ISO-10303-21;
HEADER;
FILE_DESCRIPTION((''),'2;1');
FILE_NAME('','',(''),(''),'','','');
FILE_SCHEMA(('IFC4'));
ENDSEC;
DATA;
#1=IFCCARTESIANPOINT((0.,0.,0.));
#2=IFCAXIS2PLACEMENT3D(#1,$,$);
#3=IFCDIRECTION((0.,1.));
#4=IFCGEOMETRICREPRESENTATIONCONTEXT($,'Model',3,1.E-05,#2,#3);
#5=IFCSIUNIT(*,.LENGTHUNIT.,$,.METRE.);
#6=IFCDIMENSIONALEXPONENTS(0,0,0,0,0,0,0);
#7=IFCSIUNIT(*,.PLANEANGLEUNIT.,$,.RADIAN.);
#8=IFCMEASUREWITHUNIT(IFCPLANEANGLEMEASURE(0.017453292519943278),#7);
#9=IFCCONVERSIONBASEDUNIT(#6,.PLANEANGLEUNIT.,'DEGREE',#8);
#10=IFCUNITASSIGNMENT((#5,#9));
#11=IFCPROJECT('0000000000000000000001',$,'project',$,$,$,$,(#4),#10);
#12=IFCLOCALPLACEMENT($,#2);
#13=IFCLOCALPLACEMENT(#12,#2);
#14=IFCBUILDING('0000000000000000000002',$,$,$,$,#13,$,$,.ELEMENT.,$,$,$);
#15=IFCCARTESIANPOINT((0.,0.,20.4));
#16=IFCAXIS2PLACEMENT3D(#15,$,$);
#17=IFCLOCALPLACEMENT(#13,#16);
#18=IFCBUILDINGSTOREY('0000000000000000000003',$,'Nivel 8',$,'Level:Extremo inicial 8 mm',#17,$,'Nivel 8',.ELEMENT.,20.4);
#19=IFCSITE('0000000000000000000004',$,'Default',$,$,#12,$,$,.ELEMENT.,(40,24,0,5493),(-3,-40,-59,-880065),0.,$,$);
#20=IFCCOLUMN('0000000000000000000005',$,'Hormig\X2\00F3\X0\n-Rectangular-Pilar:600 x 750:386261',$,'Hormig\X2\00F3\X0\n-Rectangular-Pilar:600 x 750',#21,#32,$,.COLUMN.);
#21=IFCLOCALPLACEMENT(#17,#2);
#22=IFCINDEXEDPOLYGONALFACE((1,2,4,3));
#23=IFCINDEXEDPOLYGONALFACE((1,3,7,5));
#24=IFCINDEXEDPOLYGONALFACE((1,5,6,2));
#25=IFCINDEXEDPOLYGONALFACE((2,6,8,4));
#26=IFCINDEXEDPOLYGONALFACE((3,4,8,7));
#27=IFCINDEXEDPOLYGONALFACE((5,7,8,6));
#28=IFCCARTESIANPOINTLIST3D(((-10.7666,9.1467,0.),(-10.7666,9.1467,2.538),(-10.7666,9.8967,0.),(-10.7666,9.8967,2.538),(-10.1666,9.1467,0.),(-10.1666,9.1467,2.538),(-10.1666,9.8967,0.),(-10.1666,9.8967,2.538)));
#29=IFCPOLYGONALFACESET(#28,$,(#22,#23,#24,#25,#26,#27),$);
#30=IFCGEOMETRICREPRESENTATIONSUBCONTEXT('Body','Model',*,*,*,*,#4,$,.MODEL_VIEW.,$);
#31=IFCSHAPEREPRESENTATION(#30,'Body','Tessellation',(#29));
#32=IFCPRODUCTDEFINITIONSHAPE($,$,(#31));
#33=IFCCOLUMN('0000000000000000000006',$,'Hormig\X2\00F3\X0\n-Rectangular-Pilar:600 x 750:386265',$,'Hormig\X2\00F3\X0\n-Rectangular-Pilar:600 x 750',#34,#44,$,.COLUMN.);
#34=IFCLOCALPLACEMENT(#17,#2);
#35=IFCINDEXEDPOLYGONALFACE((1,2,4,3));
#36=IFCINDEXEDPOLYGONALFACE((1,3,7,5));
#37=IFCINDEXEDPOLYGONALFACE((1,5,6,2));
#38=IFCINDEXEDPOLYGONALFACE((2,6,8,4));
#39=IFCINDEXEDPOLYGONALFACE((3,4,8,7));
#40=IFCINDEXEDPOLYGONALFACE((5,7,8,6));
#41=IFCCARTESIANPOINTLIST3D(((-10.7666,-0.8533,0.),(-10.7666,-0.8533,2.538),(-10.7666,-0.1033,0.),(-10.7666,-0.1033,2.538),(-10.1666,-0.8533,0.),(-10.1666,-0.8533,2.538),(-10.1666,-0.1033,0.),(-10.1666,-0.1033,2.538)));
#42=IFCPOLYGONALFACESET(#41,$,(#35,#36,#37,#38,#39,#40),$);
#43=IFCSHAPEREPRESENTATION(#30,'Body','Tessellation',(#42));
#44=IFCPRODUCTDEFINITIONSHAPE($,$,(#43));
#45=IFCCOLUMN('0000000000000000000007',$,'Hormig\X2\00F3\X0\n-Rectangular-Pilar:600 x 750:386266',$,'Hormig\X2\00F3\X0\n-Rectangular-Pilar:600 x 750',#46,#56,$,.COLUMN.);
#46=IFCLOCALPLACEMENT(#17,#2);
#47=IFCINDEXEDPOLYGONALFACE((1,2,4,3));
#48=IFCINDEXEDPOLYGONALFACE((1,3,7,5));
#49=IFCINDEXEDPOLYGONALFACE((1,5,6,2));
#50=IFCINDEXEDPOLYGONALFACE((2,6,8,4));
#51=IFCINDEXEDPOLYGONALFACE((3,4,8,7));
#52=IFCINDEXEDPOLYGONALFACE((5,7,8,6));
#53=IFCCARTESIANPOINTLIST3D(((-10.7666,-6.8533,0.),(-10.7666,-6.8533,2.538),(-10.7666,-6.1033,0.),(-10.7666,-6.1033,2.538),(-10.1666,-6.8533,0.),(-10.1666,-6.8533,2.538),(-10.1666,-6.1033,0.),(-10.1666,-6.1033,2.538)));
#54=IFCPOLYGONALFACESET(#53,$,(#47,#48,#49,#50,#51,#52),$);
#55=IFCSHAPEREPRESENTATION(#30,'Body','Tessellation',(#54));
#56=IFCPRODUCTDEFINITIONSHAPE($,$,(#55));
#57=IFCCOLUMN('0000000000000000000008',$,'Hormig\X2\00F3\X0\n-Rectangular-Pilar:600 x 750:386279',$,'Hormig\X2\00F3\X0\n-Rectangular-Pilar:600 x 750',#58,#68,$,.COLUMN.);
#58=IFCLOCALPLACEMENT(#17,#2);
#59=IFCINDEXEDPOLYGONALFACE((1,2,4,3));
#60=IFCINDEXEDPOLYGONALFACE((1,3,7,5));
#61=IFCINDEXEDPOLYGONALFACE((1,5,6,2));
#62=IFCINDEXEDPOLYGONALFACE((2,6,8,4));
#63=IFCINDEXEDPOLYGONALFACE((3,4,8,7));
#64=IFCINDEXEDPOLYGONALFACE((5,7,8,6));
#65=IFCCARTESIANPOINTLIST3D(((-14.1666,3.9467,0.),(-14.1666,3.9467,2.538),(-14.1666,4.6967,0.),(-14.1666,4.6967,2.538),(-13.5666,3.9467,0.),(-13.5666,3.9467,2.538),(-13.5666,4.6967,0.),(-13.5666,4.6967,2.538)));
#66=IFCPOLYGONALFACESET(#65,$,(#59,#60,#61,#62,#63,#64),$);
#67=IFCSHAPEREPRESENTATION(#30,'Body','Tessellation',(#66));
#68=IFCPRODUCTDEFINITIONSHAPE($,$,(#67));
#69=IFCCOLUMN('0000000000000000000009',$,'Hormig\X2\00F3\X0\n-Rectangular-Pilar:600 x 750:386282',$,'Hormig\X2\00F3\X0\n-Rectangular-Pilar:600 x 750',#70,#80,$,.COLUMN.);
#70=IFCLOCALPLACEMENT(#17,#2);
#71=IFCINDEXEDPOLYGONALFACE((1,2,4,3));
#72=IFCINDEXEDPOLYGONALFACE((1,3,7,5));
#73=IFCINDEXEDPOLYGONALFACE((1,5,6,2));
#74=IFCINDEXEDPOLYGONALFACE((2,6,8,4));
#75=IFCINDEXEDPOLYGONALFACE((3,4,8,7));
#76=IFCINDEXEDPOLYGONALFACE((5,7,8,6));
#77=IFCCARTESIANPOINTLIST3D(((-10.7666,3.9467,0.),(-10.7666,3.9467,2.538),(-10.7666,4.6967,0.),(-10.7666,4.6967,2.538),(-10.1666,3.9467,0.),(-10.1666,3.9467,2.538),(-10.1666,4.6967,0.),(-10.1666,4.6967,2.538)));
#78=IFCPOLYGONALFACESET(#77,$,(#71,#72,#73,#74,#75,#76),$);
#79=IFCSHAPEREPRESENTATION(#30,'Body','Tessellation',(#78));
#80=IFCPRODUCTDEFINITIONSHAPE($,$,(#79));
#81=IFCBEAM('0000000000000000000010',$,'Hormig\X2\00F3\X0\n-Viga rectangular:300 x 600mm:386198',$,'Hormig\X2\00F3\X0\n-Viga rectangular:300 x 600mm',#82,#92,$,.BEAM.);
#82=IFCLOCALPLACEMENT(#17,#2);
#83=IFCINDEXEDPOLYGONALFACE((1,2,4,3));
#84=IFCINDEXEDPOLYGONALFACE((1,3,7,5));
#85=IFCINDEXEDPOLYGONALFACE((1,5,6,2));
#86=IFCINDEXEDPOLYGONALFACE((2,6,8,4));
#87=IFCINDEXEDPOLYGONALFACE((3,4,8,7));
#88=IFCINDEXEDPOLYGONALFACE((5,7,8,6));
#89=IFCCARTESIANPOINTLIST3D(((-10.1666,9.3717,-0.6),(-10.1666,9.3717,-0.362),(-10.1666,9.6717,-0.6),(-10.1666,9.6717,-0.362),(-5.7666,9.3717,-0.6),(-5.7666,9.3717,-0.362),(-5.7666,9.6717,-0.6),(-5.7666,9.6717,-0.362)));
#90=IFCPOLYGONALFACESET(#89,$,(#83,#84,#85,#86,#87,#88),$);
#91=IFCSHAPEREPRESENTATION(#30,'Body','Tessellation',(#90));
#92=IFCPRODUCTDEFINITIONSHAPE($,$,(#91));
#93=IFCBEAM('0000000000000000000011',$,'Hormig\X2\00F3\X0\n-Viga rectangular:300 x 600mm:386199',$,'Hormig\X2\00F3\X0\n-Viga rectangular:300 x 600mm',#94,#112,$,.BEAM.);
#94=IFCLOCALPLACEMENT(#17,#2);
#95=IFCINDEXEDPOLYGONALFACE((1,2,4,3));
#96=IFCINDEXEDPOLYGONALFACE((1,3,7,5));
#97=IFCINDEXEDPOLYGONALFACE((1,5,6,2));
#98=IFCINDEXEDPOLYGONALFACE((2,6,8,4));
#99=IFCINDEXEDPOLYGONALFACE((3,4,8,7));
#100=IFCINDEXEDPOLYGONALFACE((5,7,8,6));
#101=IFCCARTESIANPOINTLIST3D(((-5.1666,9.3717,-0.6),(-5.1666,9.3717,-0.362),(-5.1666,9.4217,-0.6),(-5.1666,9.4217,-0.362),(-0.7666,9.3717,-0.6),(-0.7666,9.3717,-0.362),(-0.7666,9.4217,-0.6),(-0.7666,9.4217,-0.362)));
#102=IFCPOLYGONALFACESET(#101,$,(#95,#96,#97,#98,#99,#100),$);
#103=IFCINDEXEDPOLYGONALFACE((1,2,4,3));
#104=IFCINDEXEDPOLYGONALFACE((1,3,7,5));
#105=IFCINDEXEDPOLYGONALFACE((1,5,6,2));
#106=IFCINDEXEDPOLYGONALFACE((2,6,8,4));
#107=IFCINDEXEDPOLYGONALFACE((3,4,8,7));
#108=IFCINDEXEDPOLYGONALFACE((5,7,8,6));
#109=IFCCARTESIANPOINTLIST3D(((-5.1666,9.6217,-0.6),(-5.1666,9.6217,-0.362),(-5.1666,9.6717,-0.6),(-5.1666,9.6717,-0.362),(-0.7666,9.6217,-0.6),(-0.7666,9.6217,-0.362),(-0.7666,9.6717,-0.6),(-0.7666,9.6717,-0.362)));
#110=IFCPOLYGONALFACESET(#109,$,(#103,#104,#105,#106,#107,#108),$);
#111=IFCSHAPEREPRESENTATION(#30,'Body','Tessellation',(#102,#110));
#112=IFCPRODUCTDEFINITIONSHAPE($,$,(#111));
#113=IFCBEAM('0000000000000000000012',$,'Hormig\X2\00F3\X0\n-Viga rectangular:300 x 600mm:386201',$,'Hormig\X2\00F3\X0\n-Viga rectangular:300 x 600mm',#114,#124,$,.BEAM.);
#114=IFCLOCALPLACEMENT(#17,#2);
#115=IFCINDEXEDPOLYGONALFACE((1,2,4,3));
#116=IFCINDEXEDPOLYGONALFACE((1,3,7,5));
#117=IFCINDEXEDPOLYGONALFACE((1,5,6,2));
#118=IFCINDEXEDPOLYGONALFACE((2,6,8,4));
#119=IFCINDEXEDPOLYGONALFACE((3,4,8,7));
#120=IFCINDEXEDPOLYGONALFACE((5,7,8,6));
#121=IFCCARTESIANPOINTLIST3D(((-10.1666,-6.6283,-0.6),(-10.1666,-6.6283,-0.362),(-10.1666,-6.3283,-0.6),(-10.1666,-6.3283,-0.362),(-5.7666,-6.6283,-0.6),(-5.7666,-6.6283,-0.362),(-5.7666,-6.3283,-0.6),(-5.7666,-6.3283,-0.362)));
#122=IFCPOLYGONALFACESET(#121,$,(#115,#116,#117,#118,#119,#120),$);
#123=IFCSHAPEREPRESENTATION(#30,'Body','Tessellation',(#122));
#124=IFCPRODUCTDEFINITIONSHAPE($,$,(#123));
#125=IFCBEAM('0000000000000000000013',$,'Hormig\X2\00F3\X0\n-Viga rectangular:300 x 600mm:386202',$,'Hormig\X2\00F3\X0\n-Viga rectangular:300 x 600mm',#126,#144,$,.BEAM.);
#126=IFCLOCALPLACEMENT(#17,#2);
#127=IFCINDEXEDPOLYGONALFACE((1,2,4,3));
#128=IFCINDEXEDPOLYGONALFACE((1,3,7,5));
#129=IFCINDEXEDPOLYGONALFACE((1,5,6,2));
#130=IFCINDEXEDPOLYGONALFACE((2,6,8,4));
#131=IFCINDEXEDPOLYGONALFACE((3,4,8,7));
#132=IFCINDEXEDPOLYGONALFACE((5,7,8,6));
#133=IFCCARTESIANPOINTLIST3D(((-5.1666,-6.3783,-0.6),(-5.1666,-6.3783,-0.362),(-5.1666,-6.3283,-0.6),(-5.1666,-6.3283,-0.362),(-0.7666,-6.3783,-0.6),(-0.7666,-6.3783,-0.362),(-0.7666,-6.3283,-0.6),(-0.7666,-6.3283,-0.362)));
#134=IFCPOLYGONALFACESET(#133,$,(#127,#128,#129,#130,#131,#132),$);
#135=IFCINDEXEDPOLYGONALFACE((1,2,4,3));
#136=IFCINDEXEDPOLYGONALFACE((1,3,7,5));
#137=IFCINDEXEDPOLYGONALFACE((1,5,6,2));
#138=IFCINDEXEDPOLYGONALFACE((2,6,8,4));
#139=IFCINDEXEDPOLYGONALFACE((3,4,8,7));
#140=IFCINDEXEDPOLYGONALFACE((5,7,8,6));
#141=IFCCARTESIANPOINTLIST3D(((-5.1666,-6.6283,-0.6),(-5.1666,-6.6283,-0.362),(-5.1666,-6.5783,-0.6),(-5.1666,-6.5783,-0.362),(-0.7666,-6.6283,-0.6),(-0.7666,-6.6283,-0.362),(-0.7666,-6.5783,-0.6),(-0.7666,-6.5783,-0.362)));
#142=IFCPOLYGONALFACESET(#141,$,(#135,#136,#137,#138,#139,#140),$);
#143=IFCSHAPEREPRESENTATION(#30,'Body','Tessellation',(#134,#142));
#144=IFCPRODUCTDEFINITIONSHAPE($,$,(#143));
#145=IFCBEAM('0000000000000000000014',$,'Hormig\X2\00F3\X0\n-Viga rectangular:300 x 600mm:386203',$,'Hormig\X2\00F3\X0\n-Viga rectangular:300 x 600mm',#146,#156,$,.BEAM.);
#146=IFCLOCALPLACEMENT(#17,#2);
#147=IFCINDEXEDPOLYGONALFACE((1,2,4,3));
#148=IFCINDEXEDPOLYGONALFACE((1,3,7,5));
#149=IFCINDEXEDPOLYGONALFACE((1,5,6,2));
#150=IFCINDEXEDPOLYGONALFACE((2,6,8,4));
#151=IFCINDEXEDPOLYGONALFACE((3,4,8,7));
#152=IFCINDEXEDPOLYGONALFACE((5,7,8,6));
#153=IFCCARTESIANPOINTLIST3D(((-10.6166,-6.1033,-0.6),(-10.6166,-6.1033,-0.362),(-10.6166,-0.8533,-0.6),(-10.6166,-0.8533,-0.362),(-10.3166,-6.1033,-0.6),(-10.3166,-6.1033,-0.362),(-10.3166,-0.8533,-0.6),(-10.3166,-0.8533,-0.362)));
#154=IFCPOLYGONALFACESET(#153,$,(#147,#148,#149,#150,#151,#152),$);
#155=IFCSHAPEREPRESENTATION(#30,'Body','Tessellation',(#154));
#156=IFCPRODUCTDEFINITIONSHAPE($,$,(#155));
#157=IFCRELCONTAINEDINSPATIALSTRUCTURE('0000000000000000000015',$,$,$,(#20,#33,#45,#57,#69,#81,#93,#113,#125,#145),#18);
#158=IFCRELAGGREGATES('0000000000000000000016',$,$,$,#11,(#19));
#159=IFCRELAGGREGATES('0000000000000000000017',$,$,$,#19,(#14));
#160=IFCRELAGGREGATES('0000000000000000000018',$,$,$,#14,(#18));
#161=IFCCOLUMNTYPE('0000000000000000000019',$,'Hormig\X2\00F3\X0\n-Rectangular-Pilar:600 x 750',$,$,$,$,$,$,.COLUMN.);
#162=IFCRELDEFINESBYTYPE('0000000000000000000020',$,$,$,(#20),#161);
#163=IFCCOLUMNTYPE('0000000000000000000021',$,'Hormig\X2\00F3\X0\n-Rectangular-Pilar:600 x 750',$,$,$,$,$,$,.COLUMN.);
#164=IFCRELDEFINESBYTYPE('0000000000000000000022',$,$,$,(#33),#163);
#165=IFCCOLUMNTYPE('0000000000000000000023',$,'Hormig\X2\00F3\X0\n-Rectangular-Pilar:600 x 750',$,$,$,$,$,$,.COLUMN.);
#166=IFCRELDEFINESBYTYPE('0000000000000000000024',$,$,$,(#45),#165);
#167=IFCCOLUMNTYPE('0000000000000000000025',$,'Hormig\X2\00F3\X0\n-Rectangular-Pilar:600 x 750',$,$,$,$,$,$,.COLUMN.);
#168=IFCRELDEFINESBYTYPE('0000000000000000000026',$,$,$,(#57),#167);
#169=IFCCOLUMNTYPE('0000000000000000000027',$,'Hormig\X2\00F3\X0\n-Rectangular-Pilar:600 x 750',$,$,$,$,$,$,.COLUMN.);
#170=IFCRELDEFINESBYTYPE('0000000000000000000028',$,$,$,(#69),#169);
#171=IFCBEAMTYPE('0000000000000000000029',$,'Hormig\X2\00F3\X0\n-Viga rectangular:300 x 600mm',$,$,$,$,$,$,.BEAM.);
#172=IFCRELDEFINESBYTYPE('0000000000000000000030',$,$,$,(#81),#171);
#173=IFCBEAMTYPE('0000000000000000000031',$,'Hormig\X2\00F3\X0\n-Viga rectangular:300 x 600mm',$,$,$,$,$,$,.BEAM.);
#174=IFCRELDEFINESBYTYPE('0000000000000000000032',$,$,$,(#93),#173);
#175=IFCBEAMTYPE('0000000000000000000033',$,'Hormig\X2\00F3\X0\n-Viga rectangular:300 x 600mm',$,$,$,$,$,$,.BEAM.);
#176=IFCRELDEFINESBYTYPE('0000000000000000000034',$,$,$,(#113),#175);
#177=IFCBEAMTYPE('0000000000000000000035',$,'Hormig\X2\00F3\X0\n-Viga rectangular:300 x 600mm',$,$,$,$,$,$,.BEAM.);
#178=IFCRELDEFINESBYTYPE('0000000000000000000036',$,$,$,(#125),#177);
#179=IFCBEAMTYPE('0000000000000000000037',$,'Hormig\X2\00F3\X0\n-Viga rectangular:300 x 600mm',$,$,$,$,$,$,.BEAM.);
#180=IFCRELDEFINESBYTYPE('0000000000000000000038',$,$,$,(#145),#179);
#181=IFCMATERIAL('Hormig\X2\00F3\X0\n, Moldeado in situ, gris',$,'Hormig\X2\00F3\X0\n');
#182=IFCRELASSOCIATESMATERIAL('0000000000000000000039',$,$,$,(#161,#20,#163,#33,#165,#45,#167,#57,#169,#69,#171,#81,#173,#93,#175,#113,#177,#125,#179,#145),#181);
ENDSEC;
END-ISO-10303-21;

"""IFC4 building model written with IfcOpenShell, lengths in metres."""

from ifc_helpers import new_model, entity, si_unit, converted_unit, direction, frame, origin, place, context, subcontext, project, spatial, indexed_curve, outline, extrude, source, transform, mapped, material, type_object, type_shapes, element, save


model = new_model("IFC4")

# Units and contexts
model_context = context("Model", 3, precision=1e-05, world=origin(), true_north=direction((0.0, 1.0)))
body_context = subcontext(model_context, "Body", "Model", "MODEL_VIEW")
ifc_project = project(units=[si_unit("LENGTHUNIT", "METRE"), converted_unit("PLANEANGLEUNIT", "DEGREE", entity("IfcPlaneAngleMeasure", 0.017453292519943278), si_unit("PLANEANGLEUNIT", "RADIAN"), dimensions=[0, 0, 0, 0, 0, 0, 0])], contexts=[model_context])

# Site, building, storey
site_placement = place(None, origin())
site = spatial("IfcSite", under=ifc_project, at=site_placement, Name="Default", CompositionType="ELEMENT", RefLatitude=(40, 24, 0, 5493), RefLongitude=(-3, -40, -59, -880065), RefElevation=0.0)
building_placement = place(site_placement, origin())
building = spatial("IfcBuilding", under=site, at=building_placement, CompositionType="ELEMENT")
storey_placement = place(building_placement, frame((0.0, 0.0, 20.4)))
storey = spatial("IfcBuildingStorey", under=building, at=storey_placement, Name="Nivel 8", ObjectType="Level:Extremo inicial 8 mm", LongName="Nivel 8", CompositionType="ELEMENT", Elevation=20.4)

# Columns
ifc_material_1 = material(Name="Hormigón, Moldeado in situ, gris", Category="Hormigón")
column_type_1 = type_object("IfcColumnType", Name="Hormigón-Rectangular-Pilar:600 x 750", PredefinedType="COLUMN", material=ifc_material_1)
shared_shape_1 = source(origin(), body_context, "Body", "SweptSolid", [
    extrude(outline(indexed_curve([(-0.3, -0.375), (0.3, -0.375), (0.3, 0.375), (-0.3, 0.375), (-0.3, -0.375)], self_intersect=False)), frame((-10.4666, 9.5217, 20.4), z_axis=(0.0, 0.0, 1.0), x_axis=(-1.0, 0.0, 0.0)), (0.0, 0.0, 1.0), 2.538),
])
type_shapes(column_type_1, [shared_shape_1])
column_1_placement = place(storey_placement, frame((0.0, 0.0, -20.4)))
element("IfcColumn", 1, at=column_1_placement, inside=storey, type_object=column_type_1, material=ifc_material_1, Name="Hormigón-Rectangular-Pilar:600 x 750:386261", ObjectType="Hormigón-Rectangular-Pilar:600 x 750", PredefinedType="COLUMN", context=body_context, shape_type="MappedRepresentation", body=[
    mapped(shared_shape_1, transform((0.0, 0.0, 0.0), scale=1.0)),
])
column_type_2 = type_object("IfcColumnType", Name="Hormigón-Rectangular-Pilar:600 x 750", PredefinedType="COLUMN", material=ifc_material_1)
shared_shape_2 = source(origin(), body_context, "Body", "SweptSolid", [
    extrude(outline(indexed_curve([(-0.3, -0.375), (0.3, -0.375), (0.3, 0.375), (-0.3, 0.375), (-0.3, -0.375)], self_intersect=False)), frame((-10.4666, -0.4783, 20.4), z_axis=(0.0, 0.0, 1.0), x_axis=(-1.0, 0.0, 0.0)), (0.0, 0.0, 1.0), 2.538),
])
type_shapes(column_type_2, [shared_shape_2])
column_2_placement = place(storey_placement, frame((0.0, 0.0, -20.4)))
element("IfcColumn", 2, at=column_2_placement, inside=storey, type_object=column_type_2, material=ifc_material_1, Name="Hormigón-Rectangular-Pilar:600 x 750:386265", ObjectType="Hormigón-Rectangular-Pilar:600 x 750", PredefinedType="COLUMN", context=body_context, shape_type="MappedRepresentation", body=[
    mapped(shared_shape_2, transform((0.0, 0.0, 0.0), scale=1.0)),
])
column_type_3 = type_object("IfcColumnType", Name="Hormigón-Rectangular-Pilar:600 x 750", PredefinedType="COLUMN", material=ifc_material_1)
shared_shape_3 = source(origin(), body_context, "Body", "SweptSolid", [
    extrude(outline(indexed_curve([(-0.3, -0.375), (0.3, -0.375), (0.3, 0.375), (-0.3, 0.375), (-0.3, -0.375)], self_intersect=False)), frame((-10.4666, -6.4783, 20.4), z_axis=(0.0, 0.0, 1.0), x_axis=(-1.0, 0.0, 0.0)), (0.0, 0.0, 1.0), 2.538),
])
type_shapes(column_type_3, [shared_shape_3])
column_3_placement = place(storey_placement, frame((0.0, 0.0, -20.4)))
element("IfcColumn", 3, at=column_3_placement, inside=storey, type_object=column_type_3, material=ifc_material_1, Name="Hormigón-Rectangular-Pilar:600 x 750:386266", ObjectType="Hormigón-Rectangular-Pilar:600 x 750", PredefinedType="COLUMN", context=body_context, shape_type="MappedRepresentation", body=[
    mapped(shared_shape_3, transform((0.0, 0.0, 0.0), scale=1.0)),
])
column_type_4 = type_object("IfcColumnType", Name="Hormigón-Rectangular-Pilar:600 x 750", PredefinedType="COLUMN", material=ifc_material_1)
shared_shape_4 = source(origin(), body_context, "Body", "SweptSolid", [
    extrude(outline(indexed_curve([(-0.3, -0.375), (0.3, -0.375), (0.3, 0.375), (-0.3, 0.375), (-0.3, -0.375)], self_intersect=False)), frame((-13.8666, 4.3217, 20.4), z_axis=(0.0, 0.0, 1.0), x_axis=(-1.0, 0.0, 0.0)), (0.0, 0.0, 1.0), 2.538),
])
type_shapes(column_type_4, [shared_shape_4])
column_4_placement = place(storey_placement, frame((0.0, 0.0, -20.4)))
element("IfcColumn", 4, at=column_4_placement, inside=storey, type_object=column_type_4, material=ifc_material_1, Name="Hormigón-Rectangular-Pilar:600 x 750:386279", ObjectType="Hormigón-Rectangular-Pilar:600 x 750", PredefinedType="COLUMN", context=body_context, shape_type="MappedRepresentation", body=[
    mapped(shared_shape_4, transform((0.0, 0.0, 0.0), scale=1.0)),
])
column_type_5 = type_object("IfcColumnType", Name="Hormigón-Rectangular-Pilar:600 x 750", PredefinedType="COLUMN", material=ifc_material_1)
shared_shape_5 = source(origin(), body_context, "Body", "SweptSolid", [
    extrude(outline(indexed_curve([(-0.3, -0.375), (0.3, -0.375), (0.3, 0.375), (-0.3, 0.375), (-0.3, -0.375)], self_intersect=False)), frame((-10.4666, 4.3217, 20.4), z_axis=(0.0, 0.0, 1.0), x_axis=(-1.0, 0.0, 0.0)), (0.0, 0.0, 1.0), 2.538),
])
type_shapes(column_type_5, [shared_shape_5])
column_5_placement = place(storey_placement, frame((0.0, 0.0, -20.4)))
element("IfcColumn", 5, at=column_5_placement, inside=storey, type_object=column_type_5, material=ifc_material_1, Name="Hormigón-Rectangular-Pilar:600 x 750:386282", ObjectType="Hormigón-Rectangular-Pilar:600 x 750", PredefinedType="COLUMN", context=body_context, shape_type="MappedRepresentation", body=[
    mapped(shared_shape_5, transform((0.0, 0.0, 0.0), scale=1.0)),
])

# Beams
beam_type_1 = type_object("IfcBeamType", Name="Hormigón-Viga rectangular:300 x 600mm", PredefinedType="BEAM", material=ifc_material_1)
shared_shape_6 = source(origin(), body_context, "Body", "SweptSolid", [
    extrude(outline(indexed_curve([(-0.119, -0.15), (0.119, -0.15), (0.119, 0.15), (-0.119, 0.15), (-0.119, -0.15)], self_intersect=False)), frame((-5.7666, 9.5217, 19.919), z_axis=(-1.0, 0.0, 0.0), x_axis=(0.0, 0.0, -1.0)), (0.0, 0.0, 1.0), 4.4),
])
type_shapes(beam_type_1, [shared_shape_6])
beam_1_placement = place(storey_placement, frame((0.0, 0.0, -20.4)))
element("IfcBeam", 6, at=beam_1_placement, inside=storey, type_object=beam_type_1, material=ifc_material_1, Name="Hormigón-Viga rectangular:300 x 600mm:386198", ObjectType="Hormigón-Viga rectangular:300 x 600mm", PredefinedType="BEAM", context=body_context, shape_type="MappedRepresentation", body=[
    mapped(shared_shape_6, transform((0.0, 0.0, 0.0), scale=1.0)),
])
beam_type_2 = type_object("IfcBeamType", Name="Hormigón-Viga rectangular:300 x 600mm", PredefinedType="BEAM", material=ifc_material_1)
shared_shape_7 = source(origin(), body_context, "Body", "SweptSolid", [
    extrude(outline(indexed_curve([(-0.119, -0.025), (0.119, -0.025), (0.119, 0.025), (-0.119, 0.025), (-0.119, -0.025)], self_intersect=False)), frame((-5.1666, 9.3967, 19.919), z_axis=(1.0, 0.0, 0.0), x_axis=(0.0, 0.0, -1.0)), (0.0, 0.0, 1.0), 4.4),
    extrude(outline(indexed_curve([(-0.119, -0.025), (0.119, -0.025), (0.119, 0.025), (-0.119, 0.025), (-0.119, -0.025)], self_intersect=False)), frame((-5.1666, 9.6467, 19.919), z_axis=(1.0, 0.0, 0.0), x_axis=(0.0, 0.0, -1.0)), (0.0, 0.0, 1.0), 4.4),
])
type_shapes(beam_type_2, [shared_shape_7])
beam_2_placement = place(storey_placement, frame((0.0, 0.0, -20.4)))
element("IfcBeam", 7, at=beam_2_placement, inside=storey, type_object=beam_type_2, material=ifc_material_1, Name="Hormigón-Viga rectangular:300 x 600mm:386199", ObjectType="Hormigón-Viga rectangular:300 x 600mm", PredefinedType="BEAM", context=body_context, shape_type="MappedRepresentation", body=[
    mapped(shared_shape_7, transform((0.0, 0.0, 0.0), scale=1.0)),
])
beam_type_3 = type_object("IfcBeamType", Name="Hormigón-Viga rectangular:300 x 600mm", PredefinedType="BEAM", material=ifc_material_1)
shared_shape_8 = source(origin(), body_context, "Body", "SweptSolid", [
    extrude(outline(indexed_curve([(-0.119, -0.15), (0.119, -0.15), (0.119, 0.15), (-0.119, 0.15), (-0.119, -0.15)], self_intersect=False)), frame((-10.1666, -6.4783, 19.919), z_axis=(1.0, 0.0, 0.0), x_axis=(0.0, 0.0, -1.0)), (0.0, 0.0, 1.0), 4.4),
])
type_shapes(beam_type_3, [shared_shape_8])
beam_3_placement = place(storey_placement, frame((0.0, 0.0, -20.4)))
element("IfcBeam", 8, at=beam_3_placement, inside=storey, type_object=beam_type_3, material=ifc_material_1, Name="Hormigón-Viga rectangular:300 x 600mm:386201", ObjectType="Hormigón-Viga rectangular:300 x 600mm", PredefinedType="BEAM", context=body_context, shape_type="MappedRepresentation", body=[
    mapped(shared_shape_8, transform((0.0, 0.0, 0.0), scale=1.0)),
])
beam_type_4 = type_object("IfcBeamType", Name="Hormigón-Viga rectangular:300 x 600mm", PredefinedType="BEAM", material=ifc_material_1)
shared_shape_9 = source(origin(), body_context, "Body", "SweptSolid", [
    extrude(outline(indexed_curve([(-0.119, -0.025), (0.119, -0.025), (0.119, 0.025), (-0.119, 0.025), (-0.119, -0.025)], self_intersect=False)), frame((-0.7666, -6.3533, 19.919), z_axis=(-1.0, 0.0, 0.0), x_axis=(0.0, 0.0, -1.0)), (0.0, 0.0, 1.0), 4.4),
    extrude(outline(indexed_curve([(-0.119, -0.025), (0.119, -0.025), (0.119, 0.025), (-0.119, 0.025), (-0.119, -0.025)], self_intersect=False)), frame((-0.7666, -6.6033, 19.919), z_axis=(-1.0, 0.0, 0.0), x_axis=(0.0, 0.0, -1.0)), (0.0, 0.0, 1.0), 4.4),
])
type_shapes(beam_type_4, [shared_shape_9])
beam_4_placement = place(storey_placement, frame((0.0, 0.0, -20.4)))
element("IfcBeam", 9, at=beam_4_placement, inside=storey, type_object=beam_type_4, material=ifc_material_1, Name="Hormigón-Viga rectangular:300 x 600mm:386202", ObjectType="Hormigón-Viga rectangular:300 x 600mm", PredefinedType="BEAM", context=body_context, shape_type="MappedRepresentation", body=[
    mapped(shared_shape_9, transform((0.0, 0.0, 0.0), scale=1.0)),
])
beam_type_5 = type_object("IfcBeamType", Name="Hormigón-Viga rectangular:300 x 600mm", PredefinedType="BEAM", material=ifc_material_1)
shared_shape_10 = source(origin(), body_context, "Body", "SweptSolid", [
    extrude(outline(indexed_curve([(-0.15, -0.119), (0.15, -0.119), (0.15, 0.119), (-0.15, 0.119), (-0.15, -0.119)], self_intersect=False)), frame((-10.4666, -6.1033, 19.919), z_axis=(0.0, 1.0, 0.0), x_axis=(-1.0, 0.0, 0.0)), (0.0, 0.0, 1.0), 5.25),
])
type_shapes(beam_type_5, [shared_shape_10])
beam_5_placement = place(storey_placement, frame((0.0, 0.0, -20.4)))
element("IfcBeam", 10, at=beam_5_placement, inside=storey, type_object=beam_type_5, material=ifc_material_1, Name="Hormigón-Viga rectangular:300 x 600mm:386203", ObjectType="Hormigón-Viga rectangular:300 x 600mm", PredefinedType="BEAM", context=body_context, shape_type="MappedRepresentation", body=[
    mapped(shared_shape_10, transform((0.0, 0.0, 0.0), scale=1.0)),
])

save(model, "model.ifc")
